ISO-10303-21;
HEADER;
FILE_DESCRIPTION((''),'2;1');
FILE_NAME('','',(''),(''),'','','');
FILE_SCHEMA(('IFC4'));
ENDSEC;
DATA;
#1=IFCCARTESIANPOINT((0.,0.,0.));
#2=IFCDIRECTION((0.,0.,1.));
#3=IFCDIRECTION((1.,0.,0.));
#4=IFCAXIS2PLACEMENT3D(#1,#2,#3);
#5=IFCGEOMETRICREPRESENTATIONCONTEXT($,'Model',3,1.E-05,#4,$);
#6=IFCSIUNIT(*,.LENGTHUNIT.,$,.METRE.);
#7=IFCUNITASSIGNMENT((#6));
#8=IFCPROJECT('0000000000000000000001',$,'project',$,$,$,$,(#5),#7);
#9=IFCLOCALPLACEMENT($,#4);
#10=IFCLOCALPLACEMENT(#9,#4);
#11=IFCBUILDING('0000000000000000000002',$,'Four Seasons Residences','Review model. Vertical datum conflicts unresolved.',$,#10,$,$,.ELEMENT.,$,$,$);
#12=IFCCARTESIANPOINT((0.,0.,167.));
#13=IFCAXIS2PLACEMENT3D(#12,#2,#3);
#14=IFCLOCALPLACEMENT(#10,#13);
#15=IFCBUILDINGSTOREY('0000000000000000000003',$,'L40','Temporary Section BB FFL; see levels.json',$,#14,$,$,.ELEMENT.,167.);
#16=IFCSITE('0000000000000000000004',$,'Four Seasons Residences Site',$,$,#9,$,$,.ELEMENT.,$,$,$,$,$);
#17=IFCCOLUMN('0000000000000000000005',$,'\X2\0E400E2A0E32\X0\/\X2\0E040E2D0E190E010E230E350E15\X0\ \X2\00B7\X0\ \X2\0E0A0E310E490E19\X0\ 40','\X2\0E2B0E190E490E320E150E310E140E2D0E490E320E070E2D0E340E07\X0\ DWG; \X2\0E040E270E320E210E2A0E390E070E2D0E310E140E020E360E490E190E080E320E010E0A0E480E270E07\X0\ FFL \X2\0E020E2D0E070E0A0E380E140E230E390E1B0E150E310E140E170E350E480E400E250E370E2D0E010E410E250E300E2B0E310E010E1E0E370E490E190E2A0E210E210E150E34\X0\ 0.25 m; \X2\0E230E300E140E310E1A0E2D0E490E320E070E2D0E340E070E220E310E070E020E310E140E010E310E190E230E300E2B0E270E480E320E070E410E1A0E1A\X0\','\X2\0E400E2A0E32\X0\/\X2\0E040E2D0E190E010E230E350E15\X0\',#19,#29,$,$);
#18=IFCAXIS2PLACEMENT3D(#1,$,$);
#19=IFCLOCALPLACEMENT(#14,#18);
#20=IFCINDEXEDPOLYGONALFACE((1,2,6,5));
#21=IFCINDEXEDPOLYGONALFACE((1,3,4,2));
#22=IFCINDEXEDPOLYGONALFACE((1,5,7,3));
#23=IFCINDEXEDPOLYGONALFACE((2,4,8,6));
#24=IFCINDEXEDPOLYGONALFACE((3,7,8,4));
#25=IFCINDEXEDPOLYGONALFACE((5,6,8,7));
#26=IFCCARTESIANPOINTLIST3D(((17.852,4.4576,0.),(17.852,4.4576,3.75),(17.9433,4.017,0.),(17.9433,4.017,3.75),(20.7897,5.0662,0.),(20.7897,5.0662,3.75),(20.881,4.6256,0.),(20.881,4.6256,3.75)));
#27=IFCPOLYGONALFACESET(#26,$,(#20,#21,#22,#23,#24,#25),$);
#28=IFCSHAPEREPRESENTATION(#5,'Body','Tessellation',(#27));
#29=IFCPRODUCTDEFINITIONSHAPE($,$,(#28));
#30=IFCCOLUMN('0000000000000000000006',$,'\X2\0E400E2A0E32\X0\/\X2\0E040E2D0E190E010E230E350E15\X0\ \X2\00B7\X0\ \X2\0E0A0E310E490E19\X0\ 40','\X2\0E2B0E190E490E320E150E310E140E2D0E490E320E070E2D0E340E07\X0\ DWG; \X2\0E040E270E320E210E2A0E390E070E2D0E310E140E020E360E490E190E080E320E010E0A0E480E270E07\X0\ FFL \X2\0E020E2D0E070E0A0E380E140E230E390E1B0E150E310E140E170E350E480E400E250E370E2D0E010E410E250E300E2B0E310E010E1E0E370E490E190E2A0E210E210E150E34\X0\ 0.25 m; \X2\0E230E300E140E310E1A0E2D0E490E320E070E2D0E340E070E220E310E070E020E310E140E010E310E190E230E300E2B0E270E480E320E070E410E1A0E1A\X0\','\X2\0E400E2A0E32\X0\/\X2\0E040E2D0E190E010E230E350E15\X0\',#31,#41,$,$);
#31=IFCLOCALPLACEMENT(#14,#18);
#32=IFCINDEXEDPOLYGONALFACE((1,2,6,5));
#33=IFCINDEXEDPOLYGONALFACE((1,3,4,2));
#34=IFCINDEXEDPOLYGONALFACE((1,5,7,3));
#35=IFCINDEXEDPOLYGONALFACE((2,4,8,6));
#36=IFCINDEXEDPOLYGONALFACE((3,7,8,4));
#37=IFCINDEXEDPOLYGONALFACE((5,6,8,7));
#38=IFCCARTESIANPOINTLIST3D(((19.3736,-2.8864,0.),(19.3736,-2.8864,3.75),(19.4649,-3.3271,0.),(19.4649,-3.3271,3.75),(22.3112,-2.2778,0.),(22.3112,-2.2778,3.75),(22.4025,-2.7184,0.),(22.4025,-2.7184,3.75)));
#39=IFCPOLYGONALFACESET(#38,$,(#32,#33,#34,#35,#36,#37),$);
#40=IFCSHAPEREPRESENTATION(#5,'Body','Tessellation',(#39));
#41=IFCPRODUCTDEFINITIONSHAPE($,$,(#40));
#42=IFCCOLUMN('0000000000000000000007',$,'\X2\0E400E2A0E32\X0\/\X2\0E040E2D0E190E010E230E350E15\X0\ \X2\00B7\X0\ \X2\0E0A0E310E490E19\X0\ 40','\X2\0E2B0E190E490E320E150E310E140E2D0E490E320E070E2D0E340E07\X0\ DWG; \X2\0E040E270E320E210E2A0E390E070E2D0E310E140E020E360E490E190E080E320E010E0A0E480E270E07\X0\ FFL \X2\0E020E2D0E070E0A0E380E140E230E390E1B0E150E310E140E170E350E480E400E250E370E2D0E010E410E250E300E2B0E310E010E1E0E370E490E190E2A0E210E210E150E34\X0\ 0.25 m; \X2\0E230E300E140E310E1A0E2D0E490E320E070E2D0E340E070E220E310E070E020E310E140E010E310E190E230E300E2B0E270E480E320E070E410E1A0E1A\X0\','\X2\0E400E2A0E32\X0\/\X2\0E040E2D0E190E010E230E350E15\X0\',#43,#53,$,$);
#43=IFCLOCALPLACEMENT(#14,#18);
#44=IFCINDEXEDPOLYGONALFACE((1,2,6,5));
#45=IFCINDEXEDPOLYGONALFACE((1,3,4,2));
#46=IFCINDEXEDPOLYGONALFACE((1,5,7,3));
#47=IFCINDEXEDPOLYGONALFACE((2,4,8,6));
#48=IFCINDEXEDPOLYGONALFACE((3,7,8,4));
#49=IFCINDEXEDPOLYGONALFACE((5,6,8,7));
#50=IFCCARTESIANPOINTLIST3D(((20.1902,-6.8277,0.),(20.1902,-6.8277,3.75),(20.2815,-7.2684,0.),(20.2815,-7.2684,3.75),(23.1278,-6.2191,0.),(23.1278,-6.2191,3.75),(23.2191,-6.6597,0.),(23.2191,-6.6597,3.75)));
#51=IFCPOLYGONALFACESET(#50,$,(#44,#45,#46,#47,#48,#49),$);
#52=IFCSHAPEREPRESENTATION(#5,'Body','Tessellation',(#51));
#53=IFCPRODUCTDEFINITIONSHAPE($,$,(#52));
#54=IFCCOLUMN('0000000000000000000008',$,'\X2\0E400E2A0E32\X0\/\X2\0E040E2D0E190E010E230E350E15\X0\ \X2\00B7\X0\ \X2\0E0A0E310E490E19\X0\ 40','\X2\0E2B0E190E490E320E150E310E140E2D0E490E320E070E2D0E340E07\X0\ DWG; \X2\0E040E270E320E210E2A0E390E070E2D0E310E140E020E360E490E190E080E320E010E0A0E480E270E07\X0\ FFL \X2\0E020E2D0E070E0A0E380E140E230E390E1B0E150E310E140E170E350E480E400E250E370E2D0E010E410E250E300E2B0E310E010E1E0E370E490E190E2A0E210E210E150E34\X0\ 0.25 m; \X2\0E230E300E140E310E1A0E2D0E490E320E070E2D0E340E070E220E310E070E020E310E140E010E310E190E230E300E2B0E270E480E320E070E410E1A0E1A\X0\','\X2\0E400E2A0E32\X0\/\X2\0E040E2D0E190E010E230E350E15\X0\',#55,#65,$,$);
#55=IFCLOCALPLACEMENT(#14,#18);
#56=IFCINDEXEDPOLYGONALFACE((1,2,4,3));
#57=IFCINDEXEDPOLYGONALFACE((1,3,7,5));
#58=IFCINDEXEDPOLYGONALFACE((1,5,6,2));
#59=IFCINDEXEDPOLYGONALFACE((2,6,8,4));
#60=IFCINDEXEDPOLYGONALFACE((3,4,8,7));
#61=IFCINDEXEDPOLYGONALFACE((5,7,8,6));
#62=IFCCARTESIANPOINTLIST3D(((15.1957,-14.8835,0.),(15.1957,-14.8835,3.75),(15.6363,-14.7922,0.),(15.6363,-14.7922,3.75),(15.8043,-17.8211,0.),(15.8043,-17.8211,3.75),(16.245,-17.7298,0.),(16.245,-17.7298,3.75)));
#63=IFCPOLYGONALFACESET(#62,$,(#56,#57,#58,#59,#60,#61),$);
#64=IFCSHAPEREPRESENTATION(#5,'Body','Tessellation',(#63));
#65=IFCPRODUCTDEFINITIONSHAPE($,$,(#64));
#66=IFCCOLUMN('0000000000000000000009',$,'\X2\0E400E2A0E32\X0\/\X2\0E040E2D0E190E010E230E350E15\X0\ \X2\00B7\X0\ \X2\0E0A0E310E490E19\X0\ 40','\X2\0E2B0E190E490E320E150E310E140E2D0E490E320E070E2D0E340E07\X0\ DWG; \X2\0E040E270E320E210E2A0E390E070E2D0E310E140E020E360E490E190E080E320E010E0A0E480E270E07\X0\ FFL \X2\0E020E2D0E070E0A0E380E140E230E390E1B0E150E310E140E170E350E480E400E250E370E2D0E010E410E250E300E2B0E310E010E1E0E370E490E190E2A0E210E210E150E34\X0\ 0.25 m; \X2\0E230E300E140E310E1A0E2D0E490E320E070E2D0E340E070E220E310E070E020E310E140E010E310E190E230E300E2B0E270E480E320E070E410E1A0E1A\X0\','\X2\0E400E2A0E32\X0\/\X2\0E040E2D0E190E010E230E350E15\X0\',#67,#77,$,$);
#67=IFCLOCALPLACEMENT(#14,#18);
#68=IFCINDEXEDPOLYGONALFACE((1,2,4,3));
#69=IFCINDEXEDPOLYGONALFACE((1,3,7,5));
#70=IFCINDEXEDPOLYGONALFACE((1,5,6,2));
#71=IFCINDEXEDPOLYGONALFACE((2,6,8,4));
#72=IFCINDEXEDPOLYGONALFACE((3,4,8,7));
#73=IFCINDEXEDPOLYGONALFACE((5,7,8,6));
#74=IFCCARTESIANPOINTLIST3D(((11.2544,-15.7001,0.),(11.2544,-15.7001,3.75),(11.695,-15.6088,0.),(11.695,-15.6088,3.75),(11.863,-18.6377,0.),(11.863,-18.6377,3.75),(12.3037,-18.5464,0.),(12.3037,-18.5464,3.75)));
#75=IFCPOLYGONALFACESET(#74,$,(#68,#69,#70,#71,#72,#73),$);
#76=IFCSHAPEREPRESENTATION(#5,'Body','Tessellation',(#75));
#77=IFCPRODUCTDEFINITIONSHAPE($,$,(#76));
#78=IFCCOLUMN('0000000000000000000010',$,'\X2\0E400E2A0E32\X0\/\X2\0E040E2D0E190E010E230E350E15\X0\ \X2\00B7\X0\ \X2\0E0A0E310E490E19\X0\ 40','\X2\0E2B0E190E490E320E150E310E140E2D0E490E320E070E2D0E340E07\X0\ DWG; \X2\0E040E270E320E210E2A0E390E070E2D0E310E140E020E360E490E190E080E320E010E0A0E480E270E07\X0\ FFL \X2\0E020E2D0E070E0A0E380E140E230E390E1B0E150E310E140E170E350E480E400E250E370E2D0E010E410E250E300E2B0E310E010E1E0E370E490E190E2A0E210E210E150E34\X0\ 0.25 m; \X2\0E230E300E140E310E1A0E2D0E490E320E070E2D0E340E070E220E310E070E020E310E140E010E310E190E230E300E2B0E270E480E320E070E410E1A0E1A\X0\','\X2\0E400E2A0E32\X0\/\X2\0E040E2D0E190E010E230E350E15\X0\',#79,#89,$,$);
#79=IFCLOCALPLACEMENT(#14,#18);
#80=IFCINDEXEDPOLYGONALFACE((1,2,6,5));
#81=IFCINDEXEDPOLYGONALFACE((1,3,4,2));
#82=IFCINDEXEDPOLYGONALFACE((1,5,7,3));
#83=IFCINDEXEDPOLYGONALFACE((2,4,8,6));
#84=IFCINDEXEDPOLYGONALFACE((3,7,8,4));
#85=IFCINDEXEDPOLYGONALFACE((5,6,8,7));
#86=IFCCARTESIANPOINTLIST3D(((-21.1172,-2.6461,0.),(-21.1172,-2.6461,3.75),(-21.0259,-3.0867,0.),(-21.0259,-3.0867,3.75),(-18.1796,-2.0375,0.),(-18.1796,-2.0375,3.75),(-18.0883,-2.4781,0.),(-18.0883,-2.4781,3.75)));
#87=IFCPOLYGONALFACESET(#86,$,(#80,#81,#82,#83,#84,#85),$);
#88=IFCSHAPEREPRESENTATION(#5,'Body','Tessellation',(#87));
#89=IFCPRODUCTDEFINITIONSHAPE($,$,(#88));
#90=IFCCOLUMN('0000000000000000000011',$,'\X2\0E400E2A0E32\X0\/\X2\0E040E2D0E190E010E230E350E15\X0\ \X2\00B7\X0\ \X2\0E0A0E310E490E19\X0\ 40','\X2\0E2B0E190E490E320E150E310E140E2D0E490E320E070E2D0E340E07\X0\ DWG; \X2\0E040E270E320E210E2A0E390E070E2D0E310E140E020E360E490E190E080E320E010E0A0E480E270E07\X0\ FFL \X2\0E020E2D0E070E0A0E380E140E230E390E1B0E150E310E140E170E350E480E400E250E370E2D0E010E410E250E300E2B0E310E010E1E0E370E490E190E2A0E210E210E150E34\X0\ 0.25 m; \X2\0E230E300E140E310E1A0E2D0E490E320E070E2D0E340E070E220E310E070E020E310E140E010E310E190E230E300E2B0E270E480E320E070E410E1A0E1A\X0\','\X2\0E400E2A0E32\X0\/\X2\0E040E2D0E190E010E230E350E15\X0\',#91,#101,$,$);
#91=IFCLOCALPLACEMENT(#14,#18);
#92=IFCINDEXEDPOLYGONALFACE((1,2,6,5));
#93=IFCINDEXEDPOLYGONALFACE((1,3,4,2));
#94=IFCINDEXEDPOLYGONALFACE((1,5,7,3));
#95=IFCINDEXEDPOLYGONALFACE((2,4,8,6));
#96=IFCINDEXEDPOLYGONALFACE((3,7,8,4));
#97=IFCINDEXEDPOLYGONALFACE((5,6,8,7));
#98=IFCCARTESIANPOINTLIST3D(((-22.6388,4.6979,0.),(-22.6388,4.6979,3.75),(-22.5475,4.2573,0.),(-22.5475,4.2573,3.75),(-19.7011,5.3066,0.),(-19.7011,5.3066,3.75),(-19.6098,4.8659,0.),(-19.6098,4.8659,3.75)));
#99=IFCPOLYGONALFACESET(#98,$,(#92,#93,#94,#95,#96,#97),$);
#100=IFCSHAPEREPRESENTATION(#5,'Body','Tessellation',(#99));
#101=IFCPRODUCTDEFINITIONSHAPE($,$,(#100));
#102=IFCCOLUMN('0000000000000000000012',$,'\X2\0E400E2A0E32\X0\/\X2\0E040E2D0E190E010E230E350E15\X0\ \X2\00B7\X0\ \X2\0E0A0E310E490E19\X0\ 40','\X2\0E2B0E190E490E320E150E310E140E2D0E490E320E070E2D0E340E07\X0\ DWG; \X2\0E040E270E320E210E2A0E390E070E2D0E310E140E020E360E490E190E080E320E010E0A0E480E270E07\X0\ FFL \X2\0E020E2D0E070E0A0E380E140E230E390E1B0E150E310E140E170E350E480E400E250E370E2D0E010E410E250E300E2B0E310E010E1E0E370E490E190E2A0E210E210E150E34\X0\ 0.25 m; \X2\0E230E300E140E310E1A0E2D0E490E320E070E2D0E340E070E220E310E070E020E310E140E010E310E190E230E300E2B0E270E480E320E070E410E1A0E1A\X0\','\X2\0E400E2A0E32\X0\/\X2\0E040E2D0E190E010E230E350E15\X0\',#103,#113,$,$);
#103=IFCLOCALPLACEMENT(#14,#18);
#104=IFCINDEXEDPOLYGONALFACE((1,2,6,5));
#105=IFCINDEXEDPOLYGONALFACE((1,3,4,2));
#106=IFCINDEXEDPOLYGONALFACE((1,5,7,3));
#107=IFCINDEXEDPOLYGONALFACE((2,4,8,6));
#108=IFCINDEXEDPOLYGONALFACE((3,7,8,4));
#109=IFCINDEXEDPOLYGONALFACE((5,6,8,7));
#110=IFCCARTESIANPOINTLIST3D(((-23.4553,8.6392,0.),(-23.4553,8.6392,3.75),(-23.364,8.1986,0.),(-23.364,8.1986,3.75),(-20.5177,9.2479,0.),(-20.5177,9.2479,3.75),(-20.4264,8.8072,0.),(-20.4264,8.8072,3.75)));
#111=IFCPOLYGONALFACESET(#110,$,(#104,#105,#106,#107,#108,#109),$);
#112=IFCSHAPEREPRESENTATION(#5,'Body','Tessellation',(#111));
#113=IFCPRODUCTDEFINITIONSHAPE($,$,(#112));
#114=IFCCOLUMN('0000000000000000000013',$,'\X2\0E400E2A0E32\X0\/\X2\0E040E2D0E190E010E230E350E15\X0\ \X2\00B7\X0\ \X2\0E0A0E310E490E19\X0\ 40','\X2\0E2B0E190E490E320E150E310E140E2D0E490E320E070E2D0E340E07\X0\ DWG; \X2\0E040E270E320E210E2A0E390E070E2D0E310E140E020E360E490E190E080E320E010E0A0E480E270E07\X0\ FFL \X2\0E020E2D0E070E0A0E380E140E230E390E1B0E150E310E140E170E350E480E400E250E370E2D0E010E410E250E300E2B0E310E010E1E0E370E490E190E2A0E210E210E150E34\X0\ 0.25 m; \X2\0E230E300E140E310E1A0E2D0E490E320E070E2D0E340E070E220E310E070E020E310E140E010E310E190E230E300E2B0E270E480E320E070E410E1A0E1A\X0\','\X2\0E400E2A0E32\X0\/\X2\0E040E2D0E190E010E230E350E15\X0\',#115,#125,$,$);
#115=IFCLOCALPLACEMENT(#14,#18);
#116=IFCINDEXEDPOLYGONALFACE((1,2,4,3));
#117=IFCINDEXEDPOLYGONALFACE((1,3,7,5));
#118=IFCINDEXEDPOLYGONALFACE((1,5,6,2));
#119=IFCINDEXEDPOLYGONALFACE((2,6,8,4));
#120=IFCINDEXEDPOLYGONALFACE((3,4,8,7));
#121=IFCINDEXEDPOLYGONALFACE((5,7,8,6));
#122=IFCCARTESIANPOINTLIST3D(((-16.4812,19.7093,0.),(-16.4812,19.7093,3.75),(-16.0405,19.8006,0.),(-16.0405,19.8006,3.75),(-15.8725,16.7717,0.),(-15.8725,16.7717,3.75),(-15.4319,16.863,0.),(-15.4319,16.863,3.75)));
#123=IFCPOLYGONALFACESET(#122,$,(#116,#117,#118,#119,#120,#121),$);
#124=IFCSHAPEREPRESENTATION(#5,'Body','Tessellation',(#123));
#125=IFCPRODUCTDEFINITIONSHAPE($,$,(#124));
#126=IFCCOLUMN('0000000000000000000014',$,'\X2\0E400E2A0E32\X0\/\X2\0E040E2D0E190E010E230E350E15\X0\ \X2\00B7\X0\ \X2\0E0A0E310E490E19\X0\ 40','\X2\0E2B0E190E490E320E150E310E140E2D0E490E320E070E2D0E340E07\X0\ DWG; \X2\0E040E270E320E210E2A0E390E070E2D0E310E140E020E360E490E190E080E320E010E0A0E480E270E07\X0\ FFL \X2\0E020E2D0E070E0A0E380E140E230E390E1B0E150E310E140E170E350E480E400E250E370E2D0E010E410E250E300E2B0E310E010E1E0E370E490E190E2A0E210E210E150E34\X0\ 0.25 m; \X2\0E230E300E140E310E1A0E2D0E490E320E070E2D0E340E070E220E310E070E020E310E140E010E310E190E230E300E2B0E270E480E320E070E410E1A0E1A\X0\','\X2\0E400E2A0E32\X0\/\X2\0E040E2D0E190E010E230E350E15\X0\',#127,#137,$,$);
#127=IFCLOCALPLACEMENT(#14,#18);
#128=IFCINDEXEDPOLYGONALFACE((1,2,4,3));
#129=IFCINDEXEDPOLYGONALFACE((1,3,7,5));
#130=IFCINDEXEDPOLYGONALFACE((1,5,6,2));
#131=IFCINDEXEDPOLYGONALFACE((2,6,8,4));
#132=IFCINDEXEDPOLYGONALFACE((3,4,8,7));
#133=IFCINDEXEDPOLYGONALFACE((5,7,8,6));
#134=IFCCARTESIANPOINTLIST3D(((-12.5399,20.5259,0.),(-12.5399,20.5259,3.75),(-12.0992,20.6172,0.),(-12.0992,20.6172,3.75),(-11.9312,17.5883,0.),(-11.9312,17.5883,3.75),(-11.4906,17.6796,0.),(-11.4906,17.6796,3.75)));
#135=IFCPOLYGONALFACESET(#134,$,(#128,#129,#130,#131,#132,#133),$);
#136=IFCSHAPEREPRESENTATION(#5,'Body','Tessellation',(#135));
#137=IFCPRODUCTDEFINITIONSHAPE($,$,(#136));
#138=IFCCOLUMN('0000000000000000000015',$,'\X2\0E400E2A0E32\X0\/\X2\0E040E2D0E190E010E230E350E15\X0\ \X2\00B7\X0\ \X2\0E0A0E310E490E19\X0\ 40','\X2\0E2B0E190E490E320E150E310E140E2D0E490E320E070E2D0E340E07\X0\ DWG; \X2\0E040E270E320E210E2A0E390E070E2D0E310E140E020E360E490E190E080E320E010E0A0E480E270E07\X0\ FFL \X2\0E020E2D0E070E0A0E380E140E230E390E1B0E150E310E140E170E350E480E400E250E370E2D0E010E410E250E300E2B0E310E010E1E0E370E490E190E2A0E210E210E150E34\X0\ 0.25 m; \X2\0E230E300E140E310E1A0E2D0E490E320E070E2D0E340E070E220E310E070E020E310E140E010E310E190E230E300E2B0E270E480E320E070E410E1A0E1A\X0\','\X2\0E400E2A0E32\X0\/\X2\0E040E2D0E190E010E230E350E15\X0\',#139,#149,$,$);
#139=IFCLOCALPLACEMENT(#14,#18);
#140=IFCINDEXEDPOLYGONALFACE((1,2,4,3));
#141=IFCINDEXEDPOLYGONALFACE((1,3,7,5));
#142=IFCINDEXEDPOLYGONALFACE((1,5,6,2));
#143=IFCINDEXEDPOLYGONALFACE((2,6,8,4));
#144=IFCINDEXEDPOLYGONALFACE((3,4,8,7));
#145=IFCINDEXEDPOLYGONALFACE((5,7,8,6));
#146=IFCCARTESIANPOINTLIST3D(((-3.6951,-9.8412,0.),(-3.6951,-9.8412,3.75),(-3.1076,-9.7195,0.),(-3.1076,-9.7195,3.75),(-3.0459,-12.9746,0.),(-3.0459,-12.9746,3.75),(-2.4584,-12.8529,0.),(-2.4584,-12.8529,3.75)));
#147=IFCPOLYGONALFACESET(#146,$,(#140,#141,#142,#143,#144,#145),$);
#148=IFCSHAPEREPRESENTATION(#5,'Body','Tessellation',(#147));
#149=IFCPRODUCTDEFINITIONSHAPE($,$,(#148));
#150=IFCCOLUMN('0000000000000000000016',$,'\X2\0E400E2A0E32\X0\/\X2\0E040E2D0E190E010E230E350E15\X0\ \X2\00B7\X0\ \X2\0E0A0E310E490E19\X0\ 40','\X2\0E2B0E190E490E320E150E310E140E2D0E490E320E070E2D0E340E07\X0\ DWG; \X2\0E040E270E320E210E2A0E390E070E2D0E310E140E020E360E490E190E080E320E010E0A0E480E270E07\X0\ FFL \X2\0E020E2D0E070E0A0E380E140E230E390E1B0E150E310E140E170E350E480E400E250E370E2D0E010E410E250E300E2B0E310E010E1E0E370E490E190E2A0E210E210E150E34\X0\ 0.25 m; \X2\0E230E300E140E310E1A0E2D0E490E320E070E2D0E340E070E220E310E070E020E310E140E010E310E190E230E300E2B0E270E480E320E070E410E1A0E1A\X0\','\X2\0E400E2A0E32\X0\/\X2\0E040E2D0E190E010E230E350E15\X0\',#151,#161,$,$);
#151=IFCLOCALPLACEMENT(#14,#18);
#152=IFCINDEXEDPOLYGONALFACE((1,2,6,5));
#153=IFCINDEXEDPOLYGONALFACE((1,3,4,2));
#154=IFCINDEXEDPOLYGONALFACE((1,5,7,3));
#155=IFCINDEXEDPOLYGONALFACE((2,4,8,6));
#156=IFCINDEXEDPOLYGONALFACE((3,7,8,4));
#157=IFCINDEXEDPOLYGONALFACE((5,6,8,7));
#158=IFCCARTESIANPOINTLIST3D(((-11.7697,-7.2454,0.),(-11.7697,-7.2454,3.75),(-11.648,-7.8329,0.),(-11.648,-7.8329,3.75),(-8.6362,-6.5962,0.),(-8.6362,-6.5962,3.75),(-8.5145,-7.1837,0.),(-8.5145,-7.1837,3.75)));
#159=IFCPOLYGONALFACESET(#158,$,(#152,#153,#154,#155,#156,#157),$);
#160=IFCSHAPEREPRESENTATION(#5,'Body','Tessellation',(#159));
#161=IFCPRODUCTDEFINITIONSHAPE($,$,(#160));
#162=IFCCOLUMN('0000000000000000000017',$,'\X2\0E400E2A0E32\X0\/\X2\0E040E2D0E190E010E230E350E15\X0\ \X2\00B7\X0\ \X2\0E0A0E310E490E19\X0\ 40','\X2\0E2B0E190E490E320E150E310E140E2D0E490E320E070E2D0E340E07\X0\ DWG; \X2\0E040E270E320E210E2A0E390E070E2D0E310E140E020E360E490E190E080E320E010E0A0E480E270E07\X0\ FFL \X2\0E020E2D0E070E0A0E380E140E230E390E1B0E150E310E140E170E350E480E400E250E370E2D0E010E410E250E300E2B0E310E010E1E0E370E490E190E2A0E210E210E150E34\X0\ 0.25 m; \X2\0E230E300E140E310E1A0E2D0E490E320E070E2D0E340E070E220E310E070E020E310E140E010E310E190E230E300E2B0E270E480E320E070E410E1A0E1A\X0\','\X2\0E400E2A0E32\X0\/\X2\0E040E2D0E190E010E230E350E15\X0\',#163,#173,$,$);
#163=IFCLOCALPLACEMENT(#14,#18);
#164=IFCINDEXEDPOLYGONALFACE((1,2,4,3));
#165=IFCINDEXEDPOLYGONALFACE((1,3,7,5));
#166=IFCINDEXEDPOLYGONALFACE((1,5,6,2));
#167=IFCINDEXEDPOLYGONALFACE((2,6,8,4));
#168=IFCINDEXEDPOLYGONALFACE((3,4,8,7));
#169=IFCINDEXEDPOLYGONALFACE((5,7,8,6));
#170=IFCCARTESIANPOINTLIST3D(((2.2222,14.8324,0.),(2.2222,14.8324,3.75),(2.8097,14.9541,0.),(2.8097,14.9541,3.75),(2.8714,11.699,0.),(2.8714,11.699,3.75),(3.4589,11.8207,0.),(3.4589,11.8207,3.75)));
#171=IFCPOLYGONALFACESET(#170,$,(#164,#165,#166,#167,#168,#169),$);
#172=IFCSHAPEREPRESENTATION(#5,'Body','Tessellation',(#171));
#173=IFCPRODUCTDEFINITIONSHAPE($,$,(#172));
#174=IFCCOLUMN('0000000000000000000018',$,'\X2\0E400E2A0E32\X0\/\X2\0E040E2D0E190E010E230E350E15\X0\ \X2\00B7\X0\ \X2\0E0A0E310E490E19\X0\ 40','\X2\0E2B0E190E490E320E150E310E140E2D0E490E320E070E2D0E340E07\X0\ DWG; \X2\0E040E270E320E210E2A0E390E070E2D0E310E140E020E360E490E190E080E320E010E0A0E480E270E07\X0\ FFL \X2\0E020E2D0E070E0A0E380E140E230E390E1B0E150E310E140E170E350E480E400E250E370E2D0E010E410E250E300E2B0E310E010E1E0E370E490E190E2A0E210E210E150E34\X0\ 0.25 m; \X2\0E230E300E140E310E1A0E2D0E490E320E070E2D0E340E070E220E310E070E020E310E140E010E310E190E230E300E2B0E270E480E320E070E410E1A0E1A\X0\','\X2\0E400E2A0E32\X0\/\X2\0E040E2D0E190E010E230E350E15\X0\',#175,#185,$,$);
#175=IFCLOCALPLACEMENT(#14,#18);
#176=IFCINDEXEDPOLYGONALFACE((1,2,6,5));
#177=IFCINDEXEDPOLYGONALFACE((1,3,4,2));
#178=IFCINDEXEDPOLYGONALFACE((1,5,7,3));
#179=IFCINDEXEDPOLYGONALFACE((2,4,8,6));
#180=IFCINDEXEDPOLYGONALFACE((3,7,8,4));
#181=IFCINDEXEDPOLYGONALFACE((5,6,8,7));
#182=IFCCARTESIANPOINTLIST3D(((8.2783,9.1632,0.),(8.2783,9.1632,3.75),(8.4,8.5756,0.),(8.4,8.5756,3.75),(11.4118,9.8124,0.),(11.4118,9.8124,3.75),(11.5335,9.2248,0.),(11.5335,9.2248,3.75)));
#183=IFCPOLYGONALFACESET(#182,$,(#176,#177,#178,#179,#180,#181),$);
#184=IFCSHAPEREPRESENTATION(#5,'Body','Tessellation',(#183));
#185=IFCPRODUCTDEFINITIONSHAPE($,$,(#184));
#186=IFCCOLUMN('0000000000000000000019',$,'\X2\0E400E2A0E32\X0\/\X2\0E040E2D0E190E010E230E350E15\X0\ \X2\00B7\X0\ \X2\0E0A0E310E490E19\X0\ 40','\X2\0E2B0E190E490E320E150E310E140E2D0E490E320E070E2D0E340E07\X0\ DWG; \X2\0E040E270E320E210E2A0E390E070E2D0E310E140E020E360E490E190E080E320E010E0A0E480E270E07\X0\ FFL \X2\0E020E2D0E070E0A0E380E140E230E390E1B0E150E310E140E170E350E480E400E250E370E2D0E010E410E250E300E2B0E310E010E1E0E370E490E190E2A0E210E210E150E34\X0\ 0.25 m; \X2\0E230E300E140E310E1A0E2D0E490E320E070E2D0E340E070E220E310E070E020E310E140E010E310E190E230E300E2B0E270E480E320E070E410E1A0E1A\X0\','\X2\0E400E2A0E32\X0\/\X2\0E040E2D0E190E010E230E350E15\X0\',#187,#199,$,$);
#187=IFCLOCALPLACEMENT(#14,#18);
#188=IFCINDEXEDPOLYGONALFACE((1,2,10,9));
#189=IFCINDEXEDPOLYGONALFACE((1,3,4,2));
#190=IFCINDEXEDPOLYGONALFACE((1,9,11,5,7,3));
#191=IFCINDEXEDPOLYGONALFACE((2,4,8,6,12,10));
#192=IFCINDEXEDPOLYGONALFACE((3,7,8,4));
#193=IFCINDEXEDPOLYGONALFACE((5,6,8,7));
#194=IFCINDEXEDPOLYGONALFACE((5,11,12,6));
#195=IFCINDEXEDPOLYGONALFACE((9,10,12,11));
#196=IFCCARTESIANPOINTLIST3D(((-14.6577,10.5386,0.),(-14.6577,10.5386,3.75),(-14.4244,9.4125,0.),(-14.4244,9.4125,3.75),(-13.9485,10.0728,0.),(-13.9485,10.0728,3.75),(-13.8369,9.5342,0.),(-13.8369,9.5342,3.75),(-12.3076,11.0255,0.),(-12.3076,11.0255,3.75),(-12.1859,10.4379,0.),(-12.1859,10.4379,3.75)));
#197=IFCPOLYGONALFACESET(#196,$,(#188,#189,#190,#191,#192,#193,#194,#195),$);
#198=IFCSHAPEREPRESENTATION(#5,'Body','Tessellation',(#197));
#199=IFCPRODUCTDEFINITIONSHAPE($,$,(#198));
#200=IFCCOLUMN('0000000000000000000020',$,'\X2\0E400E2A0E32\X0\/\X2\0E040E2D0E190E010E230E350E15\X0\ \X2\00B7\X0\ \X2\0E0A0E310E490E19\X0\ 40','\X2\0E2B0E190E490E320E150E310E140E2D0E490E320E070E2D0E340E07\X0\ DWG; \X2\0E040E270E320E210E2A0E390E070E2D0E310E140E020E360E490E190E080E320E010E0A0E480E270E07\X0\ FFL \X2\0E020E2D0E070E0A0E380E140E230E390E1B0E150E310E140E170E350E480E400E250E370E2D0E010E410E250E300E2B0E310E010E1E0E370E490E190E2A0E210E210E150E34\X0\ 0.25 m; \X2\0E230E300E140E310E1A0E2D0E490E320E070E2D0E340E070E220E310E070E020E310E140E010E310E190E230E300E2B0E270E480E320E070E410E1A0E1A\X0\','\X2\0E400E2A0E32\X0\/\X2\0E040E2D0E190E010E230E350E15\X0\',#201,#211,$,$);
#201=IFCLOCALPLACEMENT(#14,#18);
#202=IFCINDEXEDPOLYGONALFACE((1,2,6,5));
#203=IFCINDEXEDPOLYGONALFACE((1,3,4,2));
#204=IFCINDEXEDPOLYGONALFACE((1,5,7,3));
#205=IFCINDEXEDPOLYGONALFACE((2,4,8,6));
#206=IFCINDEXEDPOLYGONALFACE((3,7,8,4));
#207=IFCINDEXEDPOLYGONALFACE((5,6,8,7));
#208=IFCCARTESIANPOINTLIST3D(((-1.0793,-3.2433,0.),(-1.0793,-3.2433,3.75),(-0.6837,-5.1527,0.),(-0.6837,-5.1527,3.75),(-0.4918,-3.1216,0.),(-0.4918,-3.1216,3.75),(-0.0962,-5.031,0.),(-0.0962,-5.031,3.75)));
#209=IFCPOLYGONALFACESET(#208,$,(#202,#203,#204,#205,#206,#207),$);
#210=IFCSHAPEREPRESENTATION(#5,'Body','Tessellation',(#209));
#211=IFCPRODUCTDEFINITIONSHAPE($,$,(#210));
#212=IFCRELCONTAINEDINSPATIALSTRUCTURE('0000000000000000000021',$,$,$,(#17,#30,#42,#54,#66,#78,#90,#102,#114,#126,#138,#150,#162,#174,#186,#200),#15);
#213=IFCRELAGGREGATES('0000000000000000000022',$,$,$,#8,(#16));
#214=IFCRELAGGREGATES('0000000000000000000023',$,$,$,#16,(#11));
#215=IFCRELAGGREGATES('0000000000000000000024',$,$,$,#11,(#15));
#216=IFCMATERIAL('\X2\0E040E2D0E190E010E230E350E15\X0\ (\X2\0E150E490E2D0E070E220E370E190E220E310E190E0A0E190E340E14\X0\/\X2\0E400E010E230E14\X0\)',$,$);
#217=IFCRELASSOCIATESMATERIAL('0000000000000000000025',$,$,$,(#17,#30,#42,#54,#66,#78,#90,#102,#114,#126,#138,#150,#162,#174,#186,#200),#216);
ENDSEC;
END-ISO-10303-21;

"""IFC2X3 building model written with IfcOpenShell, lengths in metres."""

from ifc_helpers import new_model, si_unit, frame, origin_with_axes, place, context, project, spatial, polyline, outline, extrude, material, element, save


model = new_model("IFC2X3")

# Units and contexts
model_context = context("Model", 3, precision=1e-05, world=origin_with_axes())
ifc_project = project(units=[si_unit("LENGTHUNIT", "METRE")], contexts=[model_context])

# Site, building, storey
site_placement = place(None, origin_with_axes())
site = spatial("IfcSite", under=ifc_project, at=site_placement, Name="Four Seasons Residences Site", CompositionType="ELEMENT")
building_placement = place(site_placement, origin_with_axes())
building = spatial("IfcBuilding", under=site, at=building_placement, Name="Four Seasons Residences", Description="Review model. Vertical datum conflicts unresolved.", CompositionType="ELEMENT")
storey_placement = place(building_placement, frame((0.0, 0.0, 167.0), z_axis=(0.0, 0.0, 1.0), x_axis=(1.0, 0.0, 0.0)))
storey = spatial("IfcBuildingStorey", under=building, at=storey_placement, Name="L40", Description="Temporary Section BB FFL; see levels.json", CompositionType="ELEMENT", Elevation=167.0)

# Columns
ifc_material = material(Name="คอนกรีต (ต้องยืนยันชนิด/เกรด)")
column_1_placement = place(storey_placement, origin_with_axes())
element("IfcColumn", 1, at=column_1_placement, inside=storey, material=ifc_material, Name="เสา/คอนกรีต · ชั้น 40", Description="หน้าตัดอ้างอิง DWG; ความสูงอัดขึ้นจากช่วง FFL ของชุดรูปตัดที่เลือกและหักพื้นสมมติ 0.25 m; ระดับอ้างอิงยังขัดกันระหว่างแบบ", ObjectType="เสา/คอนกรีต", context=model_context, shape_type="SweptSolid", body=[
    extrude(outline(polyline([(20.7897, 5.0662), (20.881, 4.6256), (17.9433, 4.017), (17.852, 4.4576), (20.7897, 5.0662)])), origin_with_axes(), (0.0, 0.0, 1.0), 3.75),
])
column_2_placement = place(storey_placement, origin_with_axes())
element("IfcColumn", 2, at=column_2_placement, inside=storey, material=ifc_material, Name="เสา/คอนกรีต · ชั้น 40", Description="หน้าตัดอ้างอิง DWG; ความสูงอัดขึ้นจากช่วง FFL ของชุดรูปตัดที่เลือกและหักพื้นสมมติ 0.25 m; ระดับอ้างอิงยังขัดกันระหว่างแบบ", ObjectType="เสา/คอนกรีต", context=model_context, shape_type="SweptSolid", body=[
    extrude(outline(polyline([(22.3112, -2.2778), (22.4025, -2.7184), (19.4649, -3.3271), (19.3736, -2.8864), (22.3112, -2.2778)])), origin_with_axes(), (0.0, 0.0, 1.0), 3.75),
])
column_3_placement = place(storey_placement, origin_with_axes())
element("IfcColumn", 3, at=column_3_placement, inside=storey, material=ifc_material, Name="เสา/คอนกรีต · ชั้น 40", Description="หน้าตัดอ้างอิง DWG; ความสูงอัดขึ้นจากช่วง FFL ของชุดรูปตัดที่เลือกและหักพื้นสมมติ 0.25 m; ระดับอ้างอิงยังขัดกันระหว่างแบบ", ObjectType="เสา/คอนกรีต", context=model_context, shape_type="SweptSolid", body=[
    extrude(outline(polyline([(23.1278, -6.2191), (23.2191, -6.6597), (20.2815, -7.2684), (20.1902, -6.8277), (23.1278, -6.2191)])), origin_with_axes(), (0.0, 0.0, 1.0), 3.75),
])
column_4_placement = place(storey_placement, origin_with_axes())
element("IfcColumn", 4, at=column_4_placement, inside=storey, material=ifc_material, Name="เสา/คอนกรีต · ชั้น 40", Description="หน้าตัดอ้างอิง DWG; ความสูงอัดขึ้นจากช่วง FFL ของชุดรูปตัดที่เลือกและหักพื้นสมมติ 0.25 m; ระดับอ้างอิงยังขัดกันระหว่างแบบ", ObjectType="เสา/คอนกรีต", context=model_context, shape_type="SweptSolid", body=[
    extrude(outline(polyline([(15.6363, -14.7922), (16.245, -17.7298), (15.8043, -17.8211), (15.1957, -14.8835), (15.6363, -14.7922)])), origin_with_axes(), (0.0, 0.0, 1.0), 3.75),
])
column_5_placement = place(storey_placement, origin_with_axes())
element("IfcColumn", 5, at=column_5_placement, inside=storey, material=ifc_material, Name="เสา/คอนกรีต · ชั้น 40", Description="หน้าตัดอ้างอิง DWG; ความสูงอัดขึ้นจากช่วง FFL ของชุดรูปตัดที่เลือกและหักพื้นสมมติ 0.25 m; ระดับอ้างอิงยังขัดกันระหว่างแบบ", ObjectType="เสา/คอนกรีต", context=model_context, shape_type="SweptSolid", body=[
    extrude(outline(polyline([(11.695, -15.6088), (12.3037, -18.5464), (11.863, -18.6377), (11.2544, -15.7001), (11.695, -15.6088)])), origin_with_axes(), (0.0, 0.0, 1.0), 3.75),
])
column_6_placement = place(storey_placement, origin_with_axes())
element("IfcColumn", 6, at=column_6_placement, inside=storey, material=ifc_material, Name="เสา/คอนกรีต · ชั้น 40", Description="หน้าตัดอ้างอิง DWG; ความสูงอัดขึ้นจากช่วง FFL ของชุดรูปตัดที่เลือกและหักพื้นสมมติ 0.25 m; ระดับอ้างอิงยังขัดกันระหว่างแบบ", ObjectType="เสา/คอนกรีต", context=model_context, shape_type="SweptSolid", body=[
    extrude(outline(polyline([(-21.0259, -3.0867), (-21.1172, -2.6461), (-18.1796, -2.0375), (-18.0883, -2.4781), (-21.0259, -3.0867)])), origin_with_axes(), (0.0, 0.0, 1.0), 3.75),
])
column_7_placement = place(storey_placement, origin_with_axes())
element("IfcColumn", 7, at=column_7_placement, inside=storey, material=ifc_material, Name="เสา/คอนกรีต · ชั้น 40", Description="หน้าตัดอ้างอิง DWG; ความสูงอัดขึ้นจากช่วง FFL ของชุดรูปตัดที่เลือกและหักพื้นสมมติ 0.25 m; ระดับอ้างอิงยังขัดกันระหว่างแบบ", ObjectType="เสา/คอนกรีต", context=model_context, shape_type="SweptSolid", body=[
    extrude(outline(polyline([(-22.5475, 4.2573), (-22.6388, 4.6979), (-19.7011, 5.3066), (-19.6098, 4.8659), (-22.5475, 4.2573)])), origin_with_axes(), (0.0, 0.0, 1.0), 3.75),
])
column_8_placement = place(storey_placement, origin_with_axes())
element("IfcColumn", 8, at=column_8_placement, inside=storey, material=ifc_material, Name="เสา/คอนกรีต · ชั้น 40", Description="หน้าตัดอ้างอิง DWG; ความสูงอัดขึ้นจากช่วง FFL ของชุดรูปตัดที่เลือกและหักพื้นสมมติ 0.25 m; ระดับอ้างอิงยังขัดกันระหว่างแบบ", ObjectType="เสา/คอนกรีต", context=model_context, shape_type="SweptSolid", body=[
    extrude(outline(polyline([(-23.364, 8.1986), (-23.4553, 8.6392), (-20.5177, 9.2479), (-20.4264, 8.8072), (-23.364, 8.1986)])), origin_with_axes(), (0.0, 0.0, 1.0), 3.75),
])
column_9_placement = place(storey_placement, origin_with_axes())
element("IfcColumn", 9, at=column_9_placement, inside=storey, material=ifc_material, Name="เสา/คอนกรีต · ชั้น 40", Description="หน้าตัดอ้างอิง DWG; ความสูงอัดขึ้นจากช่วง FFL ของชุดรูปตัดที่เลือกและหักพื้นสมมติ 0.25 m; ระดับอ้างอิงยังขัดกันระหว่างแบบ", ObjectType="เสา/คอนกรีต", context=model_context, shape_type="SweptSolid", body=[
    extrude(outline(polyline([(-15.8725, 16.7717), (-16.4812, 19.7093), (-16.0405, 19.8006), (-15.4319, 16.863), (-15.8725, 16.7717)])), origin_with_axes(), (0.0, 0.0, 1.0), 3.75),
])
column_10_placement = place(storey_placement, origin_with_axes())
element("IfcColumn", 10, at=column_10_placement, inside=storey, material=ifc_material, Name="เสา/คอนกรีต · ชั้น 40", Description="หน้าตัดอ้างอิง DWG; ความสูงอัดขึ้นจากช่วง FFL ของชุดรูปตัดที่เลือกและหักพื้นสมมติ 0.25 m; ระดับอ้างอิงยังขัดกันระหว่างแบบ", ObjectType="เสา/คอนกรีต", context=model_context, shape_type="SweptSolid", body=[
    extrude(outline(polyline([(-11.9312, 17.5883), (-12.5399, 20.5259), (-12.0992, 20.6172), (-11.4906, 17.6796), (-11.9312, 17.5883)])), origin_with_axes(), (0.0, 0.0, 1.0), 3.75),
])
column_11_placement = place(storey_placement, origin_with_axes())
element("IfcColumn", 11, at=column_11_placement, inside=storey, material=ifc_material, Name="เสา/คอนกรีต · ชั้น 40", Description="หน้าตัดอ้างอิง DWG; ความสูงอัดขึ้นจากช่วง FFL ของชุดรูปตัดที่เลือกและหักพื้นสมมติ 0.25 m; ระดับอ้างอิงยังขัดกันระหว่างแบบ", ObjectType="เสา/คอนกรีต", context=model_context, shape_type="SweptSolid", body=[
    extrude(outline(polyline([(-3.1076, -9.7195), (-2.4584, -12.8529), (-3.0459, -12.9746), (-3.6951, -9.8412), (-3.1076, -9.7195)])), origin_with_axes(), (0.0, 0.0, 1.0), 3.75),
])
column_12_placement = place(storey_placement, origin_with_axes())
element("IfcColumn", 12, at=column_12_placement, inside=storey, material=ifc_material, Name="เสา/คอนกรีต · ชั้น 40", Description="หน้าตัดอ้างอิง DWG; ความสูงอัดขึ้นจากช่วง FFL ของชุดรูปตัดที่เลือกและหักพื้นสมมติ 0.25 m; ระดับอ้างอิงยังขัดกันระหว่างแบบ", ObjectType="เสา/คอนกรีต", context=model_context, shape_type="SweptSolid", body=[
    extrude(outline(polyline([(-8.5145, -7.1837), (-11.648, -7.8329), (-11.7697, -7.2454), (-8.6362, -6.5962), (-8.5145, -7.1837)])), origin_with_axes(), (0.0, 0.0, 1.0), 3.75),
])
column_13_placement = place(storey_placement, origin_with_axes())
element("IfcColumn", 13, at=column_13_placement, inside=storey, material=ifc_material, Name="เสา/คอนกรีต · ชั้น 40", Description="หน้าตัดอ้างอิง DWG; ความสูงอัดขึ้นจากช่วง FFL ของชุดรูปตัดที่เลือกและหักพื้นสมมติ 0.25 m; ระดับอ้างอิงยังขัดกันระหว่างแบบ", ObjectType="เสา/คอนกรีต", context=model_context, shape_type="SweptSolid", body=[
    extrude(outline(polyline([(2.8097, 14.9541), (3.4589, 11.8207), (2.8714, 11.699), (2.2222, 14.8324), (2.8097, 14.9541)])), origin_with_axes(), (0.0, 0.0, 1.0), 3.75),
])
column_14_placement = place(storey_placement, origin_with_axes())
element("IfcColumn", 14, at=column_14_placement, inside=storey, material=ifc_material, Name="เสา/คอนกรีต · ชั้น 40", Description="หน้าตัดอ้างอิง DWG; ความสูงอัดขึ้นจากช่วง FFL ของชุดรูปตัดที่เลือกและหักพื้นสมมติ 0.25 m; ระดับอ้างอิงยังขัดกันระหว่างแบบ", ObjectType="เสา/คอนกรีต", context=model_context, shape_type="SweptSolid", body=[
    extrude(outline(polyline([(11.5335, 9.2248), (8.4, 8.5756), (8.2783, 9.1632), (11.4118, 9.8124), (11.5335, 9.2248)])), origin_with_axes(), (0.0, 0.0, 1.0), 3.75),
])
column_15_placement = place(storey_placement, origin_with_axes())
element("IfcColumn", 15, at=column_15_placement, inside=storey, material=ifc_material, Name="เสา/คอนกรีต · ชั้น 40", Description="หน้าตัดอ้างอิง DWG; ความสูงอัดขึ้นจากช่วง FFL ของชุดรูปตัดที่เลือกและหักพื้นสมมติ 0.25 m; ระดับอ้างอิงยังขัดกันระหว่างแบบ", ObjectType="เสา/คอนกรีต", context=model_context, shape_type="SweptSolid", body=[
    extrude(outline(polyline([(-14.4244, 9.4125), (-13.8369, 9.5342), (-13.9485, 10.0728), (-12.1859, 10.4379), (-12.3076, 11.0255), (-14.6577, 10.5386), (-14.4244, 9.4125)])), origin_with_axes(), (0.0, 0.0, 1.0), 3.75),
])
column_16_placement = place(storey_placement, origin_with_axes())
element("IfcColumn", 16, at=column_16_placement, inside=storey, material=ifc_material, Name="เสา/คอนกรีต · ชั้น 40", Description="หน้าตัดอ้างอิง DWG; ความสูงอัดขึ้นจากช่วง FFL ของชุดรูปตัดที่เลือกและหักพื้นสมมติ 0.25 m; ระดับอ้างอิงยังขัดกันระหว่างแบบ", ObjectType="เสา/คอนกรีต", context=model_context, shape_type="SweptSolid", body=[
    extrude(outline(polyline([(-0.4918, -3.1216), (-0.0962, -5.031), (-0.6837, -5.1527), (-1.0793, -3.2433), (-0.4918, -3.1216)])), origin_with_axes(), (0.0, 0.0, 1.0), 3.75),
])

save(model, "model.ifc")
